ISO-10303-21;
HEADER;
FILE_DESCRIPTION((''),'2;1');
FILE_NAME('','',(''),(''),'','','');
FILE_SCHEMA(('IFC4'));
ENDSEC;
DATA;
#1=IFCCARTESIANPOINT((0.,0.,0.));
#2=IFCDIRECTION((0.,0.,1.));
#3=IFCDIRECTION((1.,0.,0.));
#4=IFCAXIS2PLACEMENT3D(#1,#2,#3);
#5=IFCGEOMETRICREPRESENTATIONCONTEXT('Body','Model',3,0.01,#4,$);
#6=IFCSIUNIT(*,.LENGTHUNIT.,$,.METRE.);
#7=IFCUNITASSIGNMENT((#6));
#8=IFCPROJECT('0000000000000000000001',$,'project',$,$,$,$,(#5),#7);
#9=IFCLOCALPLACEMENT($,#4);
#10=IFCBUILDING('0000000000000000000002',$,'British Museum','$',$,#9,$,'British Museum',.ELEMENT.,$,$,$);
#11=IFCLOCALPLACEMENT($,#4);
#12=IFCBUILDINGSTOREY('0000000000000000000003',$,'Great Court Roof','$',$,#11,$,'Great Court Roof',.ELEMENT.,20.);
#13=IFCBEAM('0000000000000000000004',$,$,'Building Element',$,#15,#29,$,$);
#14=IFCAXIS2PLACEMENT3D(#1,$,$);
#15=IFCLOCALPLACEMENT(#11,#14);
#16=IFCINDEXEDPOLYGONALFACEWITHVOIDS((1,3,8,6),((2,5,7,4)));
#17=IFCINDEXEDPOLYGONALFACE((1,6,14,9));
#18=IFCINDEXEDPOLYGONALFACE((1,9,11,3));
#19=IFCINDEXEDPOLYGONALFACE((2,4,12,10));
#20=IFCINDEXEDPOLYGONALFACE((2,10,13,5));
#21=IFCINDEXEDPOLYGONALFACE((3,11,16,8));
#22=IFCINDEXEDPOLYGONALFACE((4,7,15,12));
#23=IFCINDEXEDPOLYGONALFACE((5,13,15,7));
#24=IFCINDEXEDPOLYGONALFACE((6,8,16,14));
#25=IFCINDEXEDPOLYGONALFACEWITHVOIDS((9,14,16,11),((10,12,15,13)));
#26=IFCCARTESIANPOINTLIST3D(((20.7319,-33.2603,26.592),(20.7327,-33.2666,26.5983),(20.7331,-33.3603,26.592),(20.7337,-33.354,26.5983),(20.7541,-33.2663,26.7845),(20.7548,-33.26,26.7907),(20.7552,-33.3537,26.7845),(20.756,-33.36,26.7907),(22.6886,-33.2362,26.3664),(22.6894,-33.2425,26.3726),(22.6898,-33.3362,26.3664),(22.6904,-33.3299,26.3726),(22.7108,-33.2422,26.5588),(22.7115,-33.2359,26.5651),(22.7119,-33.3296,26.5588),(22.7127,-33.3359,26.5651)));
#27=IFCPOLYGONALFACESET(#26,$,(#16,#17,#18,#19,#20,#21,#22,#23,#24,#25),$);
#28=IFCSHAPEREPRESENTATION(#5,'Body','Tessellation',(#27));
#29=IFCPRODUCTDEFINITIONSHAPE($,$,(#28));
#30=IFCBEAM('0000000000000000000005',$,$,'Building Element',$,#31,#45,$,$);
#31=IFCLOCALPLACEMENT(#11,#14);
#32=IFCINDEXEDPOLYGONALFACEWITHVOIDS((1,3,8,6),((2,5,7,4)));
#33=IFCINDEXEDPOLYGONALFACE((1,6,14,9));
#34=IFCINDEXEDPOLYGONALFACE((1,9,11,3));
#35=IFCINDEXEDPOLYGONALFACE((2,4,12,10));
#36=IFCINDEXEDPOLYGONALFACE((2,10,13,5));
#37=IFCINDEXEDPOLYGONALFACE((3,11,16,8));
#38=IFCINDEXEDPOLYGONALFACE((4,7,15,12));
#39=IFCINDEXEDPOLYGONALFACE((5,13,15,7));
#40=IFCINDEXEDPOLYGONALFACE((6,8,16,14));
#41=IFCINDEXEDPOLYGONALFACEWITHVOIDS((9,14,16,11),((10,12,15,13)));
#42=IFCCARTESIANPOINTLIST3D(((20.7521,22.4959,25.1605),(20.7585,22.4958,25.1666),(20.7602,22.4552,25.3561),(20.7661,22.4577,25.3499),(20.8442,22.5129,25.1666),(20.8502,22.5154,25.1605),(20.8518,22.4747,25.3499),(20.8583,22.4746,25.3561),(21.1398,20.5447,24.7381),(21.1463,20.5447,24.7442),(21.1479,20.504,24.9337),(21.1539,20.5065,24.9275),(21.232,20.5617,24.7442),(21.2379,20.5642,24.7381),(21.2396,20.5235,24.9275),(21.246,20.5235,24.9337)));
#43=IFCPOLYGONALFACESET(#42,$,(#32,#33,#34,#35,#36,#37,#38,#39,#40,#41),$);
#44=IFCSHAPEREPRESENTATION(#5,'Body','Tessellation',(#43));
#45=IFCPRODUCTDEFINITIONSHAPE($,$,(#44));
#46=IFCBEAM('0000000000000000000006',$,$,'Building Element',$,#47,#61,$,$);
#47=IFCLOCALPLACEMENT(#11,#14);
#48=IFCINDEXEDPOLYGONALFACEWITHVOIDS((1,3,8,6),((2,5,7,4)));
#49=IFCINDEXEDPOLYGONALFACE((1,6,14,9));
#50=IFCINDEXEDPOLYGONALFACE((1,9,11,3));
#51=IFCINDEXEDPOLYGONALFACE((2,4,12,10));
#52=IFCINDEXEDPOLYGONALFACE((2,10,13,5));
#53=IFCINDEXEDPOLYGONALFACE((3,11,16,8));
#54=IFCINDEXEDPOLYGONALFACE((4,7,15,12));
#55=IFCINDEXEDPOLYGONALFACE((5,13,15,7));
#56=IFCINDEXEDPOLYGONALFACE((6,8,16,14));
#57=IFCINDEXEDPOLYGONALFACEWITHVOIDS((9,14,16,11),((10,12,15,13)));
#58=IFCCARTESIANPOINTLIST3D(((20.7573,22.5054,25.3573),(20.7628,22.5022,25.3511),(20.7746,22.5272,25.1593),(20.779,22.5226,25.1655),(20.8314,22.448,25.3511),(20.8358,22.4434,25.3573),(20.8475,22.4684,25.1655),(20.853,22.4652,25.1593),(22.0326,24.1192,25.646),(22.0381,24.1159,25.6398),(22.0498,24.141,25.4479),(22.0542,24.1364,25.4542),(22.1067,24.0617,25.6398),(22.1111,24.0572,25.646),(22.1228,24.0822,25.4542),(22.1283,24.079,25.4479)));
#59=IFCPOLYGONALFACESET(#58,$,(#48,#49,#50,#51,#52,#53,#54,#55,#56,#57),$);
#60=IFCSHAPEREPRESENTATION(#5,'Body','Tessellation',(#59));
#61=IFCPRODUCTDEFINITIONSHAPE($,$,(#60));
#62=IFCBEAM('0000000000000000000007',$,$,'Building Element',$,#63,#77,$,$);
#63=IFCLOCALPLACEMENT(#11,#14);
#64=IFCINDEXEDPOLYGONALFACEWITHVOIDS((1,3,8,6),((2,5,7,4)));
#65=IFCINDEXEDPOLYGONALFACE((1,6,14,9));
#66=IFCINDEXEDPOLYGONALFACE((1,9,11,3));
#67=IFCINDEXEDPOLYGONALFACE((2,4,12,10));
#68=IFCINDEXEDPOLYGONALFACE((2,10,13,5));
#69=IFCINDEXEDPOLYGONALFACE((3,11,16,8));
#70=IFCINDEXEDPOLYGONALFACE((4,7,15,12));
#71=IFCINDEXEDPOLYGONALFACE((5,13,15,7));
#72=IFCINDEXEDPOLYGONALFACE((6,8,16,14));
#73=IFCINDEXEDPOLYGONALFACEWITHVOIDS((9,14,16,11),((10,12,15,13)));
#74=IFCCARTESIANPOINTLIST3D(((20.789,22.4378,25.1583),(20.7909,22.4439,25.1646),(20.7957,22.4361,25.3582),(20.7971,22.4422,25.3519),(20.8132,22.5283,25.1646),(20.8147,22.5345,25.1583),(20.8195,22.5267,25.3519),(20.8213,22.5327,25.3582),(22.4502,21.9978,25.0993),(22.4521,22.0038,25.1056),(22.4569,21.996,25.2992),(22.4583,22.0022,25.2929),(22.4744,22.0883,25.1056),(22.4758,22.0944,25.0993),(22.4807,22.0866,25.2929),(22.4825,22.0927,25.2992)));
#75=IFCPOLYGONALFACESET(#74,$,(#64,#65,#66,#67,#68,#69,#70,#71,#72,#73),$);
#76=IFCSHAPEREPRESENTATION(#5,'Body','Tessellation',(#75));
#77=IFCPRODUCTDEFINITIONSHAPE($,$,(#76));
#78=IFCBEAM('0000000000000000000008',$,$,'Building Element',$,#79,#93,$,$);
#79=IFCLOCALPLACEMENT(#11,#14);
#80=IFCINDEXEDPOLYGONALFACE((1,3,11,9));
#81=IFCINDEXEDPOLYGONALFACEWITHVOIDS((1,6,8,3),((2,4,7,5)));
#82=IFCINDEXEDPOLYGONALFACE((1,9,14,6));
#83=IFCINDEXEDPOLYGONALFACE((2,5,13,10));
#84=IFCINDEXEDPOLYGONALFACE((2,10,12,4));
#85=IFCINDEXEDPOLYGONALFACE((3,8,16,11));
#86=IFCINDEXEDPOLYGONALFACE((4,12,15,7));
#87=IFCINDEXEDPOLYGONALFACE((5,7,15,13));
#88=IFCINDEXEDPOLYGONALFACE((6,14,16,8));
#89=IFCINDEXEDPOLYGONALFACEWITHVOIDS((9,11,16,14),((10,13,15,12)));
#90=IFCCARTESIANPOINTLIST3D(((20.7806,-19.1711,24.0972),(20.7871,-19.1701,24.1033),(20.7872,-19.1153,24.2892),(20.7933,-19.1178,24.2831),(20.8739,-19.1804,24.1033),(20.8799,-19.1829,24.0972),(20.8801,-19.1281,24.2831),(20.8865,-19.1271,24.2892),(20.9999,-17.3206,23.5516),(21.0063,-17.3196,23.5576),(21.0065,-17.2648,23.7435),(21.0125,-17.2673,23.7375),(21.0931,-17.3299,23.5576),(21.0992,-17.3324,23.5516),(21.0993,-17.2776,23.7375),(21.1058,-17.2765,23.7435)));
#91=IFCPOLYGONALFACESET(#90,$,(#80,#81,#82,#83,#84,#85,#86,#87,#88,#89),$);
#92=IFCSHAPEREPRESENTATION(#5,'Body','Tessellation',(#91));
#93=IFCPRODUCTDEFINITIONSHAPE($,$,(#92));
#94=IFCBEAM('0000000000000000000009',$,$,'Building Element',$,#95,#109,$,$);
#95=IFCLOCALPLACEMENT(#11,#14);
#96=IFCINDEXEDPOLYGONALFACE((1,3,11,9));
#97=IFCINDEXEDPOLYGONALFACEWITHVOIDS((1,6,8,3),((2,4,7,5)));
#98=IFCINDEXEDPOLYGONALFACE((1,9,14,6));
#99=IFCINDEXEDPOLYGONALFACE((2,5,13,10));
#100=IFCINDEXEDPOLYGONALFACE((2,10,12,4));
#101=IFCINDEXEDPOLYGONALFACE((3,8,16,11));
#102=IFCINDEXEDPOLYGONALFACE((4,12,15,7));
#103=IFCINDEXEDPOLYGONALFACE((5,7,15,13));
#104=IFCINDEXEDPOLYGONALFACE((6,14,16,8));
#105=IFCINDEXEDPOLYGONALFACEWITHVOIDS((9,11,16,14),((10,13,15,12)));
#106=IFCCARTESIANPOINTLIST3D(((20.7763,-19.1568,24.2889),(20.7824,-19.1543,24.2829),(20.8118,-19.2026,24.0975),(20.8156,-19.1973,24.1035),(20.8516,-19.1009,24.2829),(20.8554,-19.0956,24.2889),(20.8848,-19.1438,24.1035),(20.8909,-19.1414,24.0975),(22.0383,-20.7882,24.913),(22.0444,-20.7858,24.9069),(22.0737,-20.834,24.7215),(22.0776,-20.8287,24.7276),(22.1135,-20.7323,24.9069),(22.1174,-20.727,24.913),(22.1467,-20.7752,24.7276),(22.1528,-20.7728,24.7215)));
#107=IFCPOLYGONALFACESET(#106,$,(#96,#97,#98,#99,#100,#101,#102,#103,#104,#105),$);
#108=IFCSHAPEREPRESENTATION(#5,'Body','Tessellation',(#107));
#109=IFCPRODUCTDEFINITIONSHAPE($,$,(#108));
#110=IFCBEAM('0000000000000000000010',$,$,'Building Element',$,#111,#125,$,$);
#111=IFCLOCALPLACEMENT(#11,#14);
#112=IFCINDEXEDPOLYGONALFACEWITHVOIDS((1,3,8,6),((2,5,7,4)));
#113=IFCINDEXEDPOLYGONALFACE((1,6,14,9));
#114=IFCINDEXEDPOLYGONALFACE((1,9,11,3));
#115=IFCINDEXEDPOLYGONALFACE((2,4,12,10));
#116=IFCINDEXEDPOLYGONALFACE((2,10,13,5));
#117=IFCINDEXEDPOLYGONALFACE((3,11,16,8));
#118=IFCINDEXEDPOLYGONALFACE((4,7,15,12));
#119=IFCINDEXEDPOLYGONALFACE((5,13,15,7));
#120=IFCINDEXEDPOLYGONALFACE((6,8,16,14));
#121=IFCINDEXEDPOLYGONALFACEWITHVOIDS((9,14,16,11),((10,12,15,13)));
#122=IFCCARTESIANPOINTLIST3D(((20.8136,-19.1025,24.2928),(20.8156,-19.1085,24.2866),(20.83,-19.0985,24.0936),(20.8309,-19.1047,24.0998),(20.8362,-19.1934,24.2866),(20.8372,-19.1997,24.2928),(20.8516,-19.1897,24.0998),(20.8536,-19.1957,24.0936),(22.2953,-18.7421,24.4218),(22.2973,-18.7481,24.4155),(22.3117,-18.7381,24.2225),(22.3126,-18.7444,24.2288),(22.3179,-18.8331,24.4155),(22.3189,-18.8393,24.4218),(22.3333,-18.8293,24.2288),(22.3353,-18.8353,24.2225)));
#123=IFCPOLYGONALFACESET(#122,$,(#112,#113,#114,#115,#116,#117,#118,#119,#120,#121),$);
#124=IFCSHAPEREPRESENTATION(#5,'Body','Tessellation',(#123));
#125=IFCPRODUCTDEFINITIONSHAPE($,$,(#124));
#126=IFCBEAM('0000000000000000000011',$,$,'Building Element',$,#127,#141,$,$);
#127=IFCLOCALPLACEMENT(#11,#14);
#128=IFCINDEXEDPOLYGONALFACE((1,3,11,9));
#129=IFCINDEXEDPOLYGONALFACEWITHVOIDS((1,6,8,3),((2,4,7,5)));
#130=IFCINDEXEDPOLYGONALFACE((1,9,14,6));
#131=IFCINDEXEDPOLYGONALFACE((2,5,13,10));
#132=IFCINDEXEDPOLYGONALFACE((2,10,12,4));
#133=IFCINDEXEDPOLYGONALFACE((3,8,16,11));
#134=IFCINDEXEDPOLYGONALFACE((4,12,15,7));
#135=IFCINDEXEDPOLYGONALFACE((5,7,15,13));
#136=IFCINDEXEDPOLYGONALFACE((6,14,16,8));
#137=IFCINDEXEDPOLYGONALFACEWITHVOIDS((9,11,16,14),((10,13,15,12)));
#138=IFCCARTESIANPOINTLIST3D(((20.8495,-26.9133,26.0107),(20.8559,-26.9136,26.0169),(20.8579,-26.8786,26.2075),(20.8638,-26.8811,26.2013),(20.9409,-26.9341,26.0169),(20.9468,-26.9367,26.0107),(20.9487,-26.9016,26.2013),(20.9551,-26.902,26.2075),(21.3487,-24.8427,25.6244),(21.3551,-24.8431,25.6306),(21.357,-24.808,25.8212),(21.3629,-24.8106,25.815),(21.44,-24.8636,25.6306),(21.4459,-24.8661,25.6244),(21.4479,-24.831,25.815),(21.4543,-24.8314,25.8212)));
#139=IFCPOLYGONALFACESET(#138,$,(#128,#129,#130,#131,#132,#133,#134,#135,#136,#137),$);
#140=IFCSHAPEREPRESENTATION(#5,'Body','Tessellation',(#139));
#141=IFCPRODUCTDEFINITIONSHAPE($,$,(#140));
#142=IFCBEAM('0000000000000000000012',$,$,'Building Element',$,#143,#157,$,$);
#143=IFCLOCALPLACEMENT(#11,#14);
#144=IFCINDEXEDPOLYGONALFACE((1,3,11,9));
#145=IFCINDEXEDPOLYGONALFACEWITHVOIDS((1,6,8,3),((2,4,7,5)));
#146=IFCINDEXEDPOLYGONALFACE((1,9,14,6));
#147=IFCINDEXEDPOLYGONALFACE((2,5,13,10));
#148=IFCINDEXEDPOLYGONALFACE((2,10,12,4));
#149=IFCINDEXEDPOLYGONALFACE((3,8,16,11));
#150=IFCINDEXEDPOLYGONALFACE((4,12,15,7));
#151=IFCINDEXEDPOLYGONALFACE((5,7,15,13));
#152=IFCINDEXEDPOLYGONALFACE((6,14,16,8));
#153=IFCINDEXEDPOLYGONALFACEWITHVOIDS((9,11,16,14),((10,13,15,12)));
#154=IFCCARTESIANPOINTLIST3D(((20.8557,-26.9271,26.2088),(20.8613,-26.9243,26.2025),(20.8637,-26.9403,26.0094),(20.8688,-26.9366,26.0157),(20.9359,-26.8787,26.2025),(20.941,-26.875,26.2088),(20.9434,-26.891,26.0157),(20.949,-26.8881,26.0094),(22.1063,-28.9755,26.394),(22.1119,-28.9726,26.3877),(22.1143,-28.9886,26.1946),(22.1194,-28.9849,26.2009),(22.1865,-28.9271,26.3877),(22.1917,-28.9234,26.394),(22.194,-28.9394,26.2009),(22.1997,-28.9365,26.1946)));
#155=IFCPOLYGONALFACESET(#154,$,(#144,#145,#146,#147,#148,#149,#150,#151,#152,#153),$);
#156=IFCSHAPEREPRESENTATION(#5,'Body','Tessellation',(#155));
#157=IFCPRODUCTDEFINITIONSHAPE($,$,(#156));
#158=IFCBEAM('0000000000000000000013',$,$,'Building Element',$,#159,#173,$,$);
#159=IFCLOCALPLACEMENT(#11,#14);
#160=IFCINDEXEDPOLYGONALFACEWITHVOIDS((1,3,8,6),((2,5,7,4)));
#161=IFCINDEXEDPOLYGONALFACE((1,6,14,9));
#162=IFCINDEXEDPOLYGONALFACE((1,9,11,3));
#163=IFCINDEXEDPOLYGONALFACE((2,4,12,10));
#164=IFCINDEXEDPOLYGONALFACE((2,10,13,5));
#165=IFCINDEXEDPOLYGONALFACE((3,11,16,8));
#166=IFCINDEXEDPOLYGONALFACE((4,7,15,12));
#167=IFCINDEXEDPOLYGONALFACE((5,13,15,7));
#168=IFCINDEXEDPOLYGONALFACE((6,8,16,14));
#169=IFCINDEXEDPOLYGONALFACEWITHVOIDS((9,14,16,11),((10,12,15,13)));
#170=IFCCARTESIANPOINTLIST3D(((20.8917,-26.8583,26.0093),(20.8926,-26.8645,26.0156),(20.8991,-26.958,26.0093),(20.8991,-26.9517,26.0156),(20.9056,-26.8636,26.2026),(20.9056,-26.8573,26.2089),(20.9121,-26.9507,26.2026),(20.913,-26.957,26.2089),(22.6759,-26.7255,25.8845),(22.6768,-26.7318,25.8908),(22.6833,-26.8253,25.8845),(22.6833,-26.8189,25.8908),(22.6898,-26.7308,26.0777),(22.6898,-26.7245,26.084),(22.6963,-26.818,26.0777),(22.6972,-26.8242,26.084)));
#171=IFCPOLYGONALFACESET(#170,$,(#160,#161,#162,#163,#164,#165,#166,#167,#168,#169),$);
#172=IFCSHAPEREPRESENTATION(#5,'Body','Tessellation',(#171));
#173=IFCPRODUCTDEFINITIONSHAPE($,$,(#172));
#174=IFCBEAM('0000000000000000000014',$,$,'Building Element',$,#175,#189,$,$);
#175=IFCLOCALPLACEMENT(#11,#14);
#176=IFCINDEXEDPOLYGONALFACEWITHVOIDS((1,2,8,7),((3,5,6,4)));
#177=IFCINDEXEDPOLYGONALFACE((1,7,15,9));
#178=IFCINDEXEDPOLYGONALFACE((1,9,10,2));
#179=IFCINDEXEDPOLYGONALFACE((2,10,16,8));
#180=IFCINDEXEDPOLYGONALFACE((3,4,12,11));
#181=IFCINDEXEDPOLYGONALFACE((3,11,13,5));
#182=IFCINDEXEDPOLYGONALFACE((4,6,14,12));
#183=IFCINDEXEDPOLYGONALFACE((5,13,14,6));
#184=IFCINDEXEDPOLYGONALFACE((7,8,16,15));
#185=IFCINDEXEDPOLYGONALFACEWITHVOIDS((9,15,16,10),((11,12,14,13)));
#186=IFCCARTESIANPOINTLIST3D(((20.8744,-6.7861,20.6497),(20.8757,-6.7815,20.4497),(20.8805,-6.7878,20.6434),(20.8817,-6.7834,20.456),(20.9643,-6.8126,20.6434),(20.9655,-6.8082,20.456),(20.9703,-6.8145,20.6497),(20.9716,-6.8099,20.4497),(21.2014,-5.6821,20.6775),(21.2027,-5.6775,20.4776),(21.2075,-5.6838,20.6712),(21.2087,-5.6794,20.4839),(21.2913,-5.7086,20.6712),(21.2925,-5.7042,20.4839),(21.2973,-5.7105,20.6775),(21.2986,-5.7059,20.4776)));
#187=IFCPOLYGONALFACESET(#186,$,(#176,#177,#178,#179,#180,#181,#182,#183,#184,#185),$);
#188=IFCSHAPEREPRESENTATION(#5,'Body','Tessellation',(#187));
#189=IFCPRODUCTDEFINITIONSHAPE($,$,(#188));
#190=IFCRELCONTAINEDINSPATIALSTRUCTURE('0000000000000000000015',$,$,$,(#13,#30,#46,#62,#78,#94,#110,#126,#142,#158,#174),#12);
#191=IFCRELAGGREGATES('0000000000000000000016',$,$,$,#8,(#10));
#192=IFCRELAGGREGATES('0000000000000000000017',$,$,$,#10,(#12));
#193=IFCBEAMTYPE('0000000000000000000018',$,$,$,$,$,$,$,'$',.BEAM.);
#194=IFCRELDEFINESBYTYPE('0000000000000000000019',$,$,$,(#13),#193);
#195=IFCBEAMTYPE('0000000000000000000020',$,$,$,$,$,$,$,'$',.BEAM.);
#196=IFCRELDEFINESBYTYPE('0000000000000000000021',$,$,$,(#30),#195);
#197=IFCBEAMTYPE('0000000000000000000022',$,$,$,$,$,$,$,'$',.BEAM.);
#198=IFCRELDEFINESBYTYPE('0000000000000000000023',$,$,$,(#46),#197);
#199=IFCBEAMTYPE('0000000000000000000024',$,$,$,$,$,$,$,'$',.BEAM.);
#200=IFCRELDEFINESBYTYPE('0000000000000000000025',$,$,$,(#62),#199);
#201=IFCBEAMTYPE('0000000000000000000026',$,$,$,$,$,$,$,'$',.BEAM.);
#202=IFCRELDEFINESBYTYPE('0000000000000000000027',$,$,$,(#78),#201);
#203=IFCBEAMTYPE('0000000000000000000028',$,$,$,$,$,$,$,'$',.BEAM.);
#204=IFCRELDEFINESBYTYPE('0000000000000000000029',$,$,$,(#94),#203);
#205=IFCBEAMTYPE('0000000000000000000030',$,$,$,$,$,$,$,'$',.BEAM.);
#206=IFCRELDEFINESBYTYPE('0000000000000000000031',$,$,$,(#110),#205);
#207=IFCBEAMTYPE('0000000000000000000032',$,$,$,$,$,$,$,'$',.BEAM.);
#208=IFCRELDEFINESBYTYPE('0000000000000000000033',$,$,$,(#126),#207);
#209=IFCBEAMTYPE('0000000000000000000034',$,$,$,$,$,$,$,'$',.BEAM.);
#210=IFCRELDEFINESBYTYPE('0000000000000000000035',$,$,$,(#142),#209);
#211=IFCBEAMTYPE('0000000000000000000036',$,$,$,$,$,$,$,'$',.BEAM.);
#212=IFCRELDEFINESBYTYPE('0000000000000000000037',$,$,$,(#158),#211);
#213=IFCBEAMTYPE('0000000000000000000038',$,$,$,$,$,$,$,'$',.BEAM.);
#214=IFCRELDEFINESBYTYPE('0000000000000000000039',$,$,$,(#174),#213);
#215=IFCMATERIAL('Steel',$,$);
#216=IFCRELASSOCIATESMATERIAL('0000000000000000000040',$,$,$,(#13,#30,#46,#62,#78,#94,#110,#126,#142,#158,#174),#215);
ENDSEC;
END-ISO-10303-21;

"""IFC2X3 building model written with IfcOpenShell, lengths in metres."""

from ifc_helpers import new_model, si_unit, frame, origin_with_axes, origin_2d, place, context, project, spatial, hollow_rectangle, extrude, material, type_object, element, save


model = new_model("IFC2X3")

# Units and contexts
model_context = context("Model", 3, precision=0.01, world=origin_with_axes(), identifier="Body")
ifc_project = project(units=[si_unit("LENGTHUNIT", "METRE")], contexts=[model_context])

# Building, storey
building_placement = place(None, origin_with_axes())
building = spatial("IfcBuilding", under=ifc_project, at=building_placement, Name="British Museum", Description="$", LongName="British Museum", CompositionType="ELEMENT")
storey_placement = place(None, origin_with_axes())
storey = spatial("IfcBuildingStorey", under=building, at=storey_placement, Name="Great Court Roof", Description="$", LongName="Great Court Roof", CompositionType="ELEMENT", Elevation=20.0)

# Beams
ifc_material = material(Name="Steel")
beam_type_1 = type_object("IfcBeamType", ElementType="$", PredefinedType="BEAM")
beam_1_placement = place(None, origin_with_axes())
element("IfcBeam", 1, at=beam_1_placement, inside=storey, type_object=beam_type_1, material=ifc_material, Description="Building Element", context=model_context, shape_type="SweptSolid", body=[
    extrude(hollow_rectangle(XDim=0.1, YDim=0.2, WallThickness=0.0063, InnerFilletRadius=0.0, OuterFilletRadius=0.0, at=origin_2d()), frame((20.7439, -33.3101, 26.6914), z_axis=(0.993342, 0.012223, -0.114555), x_axis=(-0.012304, 0.999924, 0.0)), (0.0, 0.0, 1.0), 1.9698),
])
beam_type_2 = type_object("IfcBeamType", ElementType="$", PredefinedType="BEAM")
beam_2_placement = place(None, origin_with_axes())
element("IfcBeam", 2, at=beam_2_placement, inside=storey, type_object=beam_type_2, material=ifc_material, Description="Building Element", context=model_context, shape_type="SweptSolid", body=[
    extrude(hollow_rectangle(XDim=0.1, YDim=0.2, WallThickness=0.0063, InnerFilletRadius=0.0, OuterFilletRadius=0.0, at=origin_2d()), frame((20.8052, 22.4853, 25.2583), z_axis=(0.190667, -0.959429, -0.207705), x_axis=(0.98082, 0.194918, 0.0)), (0.0, 0.0, 1.0), 2.0337),
])
beam_type_3 = type_object("IfcBeamType", ElementType="$", PredefinedType="BEAM")
beam_3_placement = place(None, origin_with_axes())
element("IfcBeam", 3, at=beam_3_placement, inside=storey, type_object=beam_type_3, material=ifc_material, Description="Building Element", context=model_context, shape_type="SweptSolid", body=[
    extrude(hollow_rectangle(XDim=0.1, YDim=0.2, WallThickness=0.0063, InnerFilletRadius=0.0, OuterFilletRadius=0.0, at=origin_2d()), frame((20.8052, 22.4853, 25.2583), z_axis=(0.613999, 0.776974, 0.138985), x_axis=(-0.784589, 0.620017, 0.0)), (0.0, 0.0, 1.0), 2.077),
])
beam_type_4 = type_object("IfcBeamType", ElementType="$", PredefinedType="BEAM")
beam_4_placement = place(None, origin_with_axes())
element("IfcBeam", 4, at=beam_4_placement, inside=storey, type_object=beam_type_4, material=ifc_material, Description="Building Element", context=model_context, shape_type="SweptSolid", body=[
    extrude(hollow_rectangle(XDim=0.1, YDim=0.2, WallThickness=0.0063, InnerFilletRadius=0.0, OuterFilletRadius=0.0, at=origin_2d()), frame((20.8052, 22.4853, 25.2583), z_axis=(0.966089, -0.255915, -0.03434), x_axis=(0.256066, 0.966659, 0.0)), (0.0, 0.0, 1.0), 1.7195),
])
beam_type_5 = type_object("IfcBeamType", ElementType="$", PredefinedType="BEAM")
beam_5_placement = place(None, origin_with_axes())
element("IfcBeam", 5, at=beam_5_placement, inside=storey, type_object=beam_type_5, material=ifc_material, Description="Building Element", context=model_context, shape_type="SweptSolid", body=[
    extrude(hollow_rectangle(XDim=0.1, YDim=0.2, WallThickness=0.0063, InnerFilletRadius=0.0, OuterFilletRadius=0.0, at=origin_2d()), frame((20.8336, -19.1491, 24.1932), z_axis=(0.112908, 0.953042, -0.281005), x_axis=(-0.993055, 0.117649, 0.0)), (0.0, 0.0, 1.0), 1.9417),
])
beam_type_6 = type_object("IfcBeamType", ElementType="$", PredefinedType="BEAM")
beam_6_placement = place(None, origin_with_axes())
element("IfcBeam", 6, at=beam_6_placement, inside=storey, type_object=beam_type_6, material=ifc_material, Description="Building Element", context=model_context, shape_type="SweptSolid", body=[
    extrude(hollow_rectangle(XDim=0.1, YDim=0.2, WallThickness=0.0063, InnerFilletRadius=0.0, OuterFilletRadius=0.0, at=origin_2d()), frame((20.8336, -19.1491, 24.1932), z_axis=(0.585617, -0.757089, 0.289602), x_axis=(0.790985, 0.611836, 0.0)), (0.0, 0.0, 1.0), 2.1549),
])
beam_type_7 = type_object("IfcBeamType", ElementType="$", PredefinedType="BEAM")
beam_7_placement = place(None, origin_with_axes())
element("IfcBeam", 7, at=beam_7_placement, inside=storey, type_object=beam_type_7, material=ifc_material, Description="Building Element", context=model_context, shape_type="SweptSolid", body=[
    extrude(hollow_rectangle(XDim=0.1, YDim=0.2, WallThickness=0.0063, InnerFilletRadius=0.0, OuterFilletRadius=0.0, at=origin_2d()), frame((20.8336, -19.1491, 24.1932), z_axis=(0.96822, 0.235475, 0.084272), x_axis=(-0.236315, 0.971676, 0.0)), (0.0, 0.0, 1.0), 1.5303),
])
beam_type_8 = type_object("IfcBeamType", ElementType="$", PredefinedType="BEAM")
beam_8_placement = place(None, origin_with_axes())
element("IfcBeam", 8, at=beam_8_placement, inside=storey, type_object=beam_type_8, material=ifc_material, Description="Building Element", context=model_context, shape_type="SweptSolid", body=[
    extrude(hollow_rectangle(XDim=0.1, YDim=0.2, WallThickness=0.0063, InnerFilletRadius=0.0, OuterFilletRadius=0.0, at=origin_2d()), frame((20.9023, -26.9076, 26.1091), z_axis=(0.230588, 0.956551, -0.178437), x_axis=(-0.972153, 0.234349, 0.0)), (0.0, 0.0, 1.0), 2.1646),
])
beam_type_9 = type_object("IfcBeamType", ElementType="$", PredefinedType="BEAM")
beam_9_placement = place(None, origin_with_axes())
element("IfcBeam", 9, at=beam_9_placement, inside=storey, type_object=beam_type_9, material=ifc_material, Description="Building Element", context=model_context, shape_type="SweptSolid", body=[
    extrude(hollow_rectangle(XDim=0.1, YDim=0.2, WallThickness=0.0063, InnerFilletRadius=0.0, OuterFilletRadius=0.0, at=origin_2d()), frame((20.9023, -26.9076, 26.1091), z_axis=(0.519566, -0.850959, 0.076943), x_axis=(0.853489, 0.521111, 0.0)), (0.0, 0.0, 1.0), 2.4071),
])
beam_type_10 = type_object("IfcBeamType", ElementType="$", PredefinedType="BEAM")
beam_10_placement = place(None, origin_with_axes())
element("IfcBeam", 10, at=beam_10_placement, inside=storey, type_object=beam_type_10, material=ifc_material, Description="Building Element", context=model_context, shape_type="SweptSolid", body=[
    extrude(hollow_rectangle(XDim=0.1, YDim=0.2, WallThickness=0.0063, InnerFilletRadius=0.0, OuterFilletRadius=0.0, at=origin_2d()), frame((20.9023, -26.9076, 26.1091), z_axis=(0.994824, 0.07402, -0.069616), x_axis=(-0.0742, 0.997243, 0.0)), (0.0, 0.0, 1.0), 1.7935),
])
beam_type_11 = type_object("IfcBeamType", ElementType="$", PredefinedType="BEAM")
beam_11_placement = place(None, origin_with_axes())
element("IfcBeam", 11, at=beam_11_placement, inside=storey, type_object=beam_type_11, material=ifc_material, Description="Building Element", context=model_context, shape_type="SweptSolid", body=[
    extrude(hollow_rectangle(XDim=0.1, YDim=0.2, WallThickness=0.0063, InnerFilletRadius=0.0, OuterFilletRadius=0.0, at=origin_2d()), frame((20.923, -6.798, 20.5497), z_axis=(0.283917, 0.958544, 0.024167), x_axis=(-0.958824, 0.284, 0.0)), (0.0, 0.0, 1.0), 1.1517),
])

save(model, "model.ifc")
